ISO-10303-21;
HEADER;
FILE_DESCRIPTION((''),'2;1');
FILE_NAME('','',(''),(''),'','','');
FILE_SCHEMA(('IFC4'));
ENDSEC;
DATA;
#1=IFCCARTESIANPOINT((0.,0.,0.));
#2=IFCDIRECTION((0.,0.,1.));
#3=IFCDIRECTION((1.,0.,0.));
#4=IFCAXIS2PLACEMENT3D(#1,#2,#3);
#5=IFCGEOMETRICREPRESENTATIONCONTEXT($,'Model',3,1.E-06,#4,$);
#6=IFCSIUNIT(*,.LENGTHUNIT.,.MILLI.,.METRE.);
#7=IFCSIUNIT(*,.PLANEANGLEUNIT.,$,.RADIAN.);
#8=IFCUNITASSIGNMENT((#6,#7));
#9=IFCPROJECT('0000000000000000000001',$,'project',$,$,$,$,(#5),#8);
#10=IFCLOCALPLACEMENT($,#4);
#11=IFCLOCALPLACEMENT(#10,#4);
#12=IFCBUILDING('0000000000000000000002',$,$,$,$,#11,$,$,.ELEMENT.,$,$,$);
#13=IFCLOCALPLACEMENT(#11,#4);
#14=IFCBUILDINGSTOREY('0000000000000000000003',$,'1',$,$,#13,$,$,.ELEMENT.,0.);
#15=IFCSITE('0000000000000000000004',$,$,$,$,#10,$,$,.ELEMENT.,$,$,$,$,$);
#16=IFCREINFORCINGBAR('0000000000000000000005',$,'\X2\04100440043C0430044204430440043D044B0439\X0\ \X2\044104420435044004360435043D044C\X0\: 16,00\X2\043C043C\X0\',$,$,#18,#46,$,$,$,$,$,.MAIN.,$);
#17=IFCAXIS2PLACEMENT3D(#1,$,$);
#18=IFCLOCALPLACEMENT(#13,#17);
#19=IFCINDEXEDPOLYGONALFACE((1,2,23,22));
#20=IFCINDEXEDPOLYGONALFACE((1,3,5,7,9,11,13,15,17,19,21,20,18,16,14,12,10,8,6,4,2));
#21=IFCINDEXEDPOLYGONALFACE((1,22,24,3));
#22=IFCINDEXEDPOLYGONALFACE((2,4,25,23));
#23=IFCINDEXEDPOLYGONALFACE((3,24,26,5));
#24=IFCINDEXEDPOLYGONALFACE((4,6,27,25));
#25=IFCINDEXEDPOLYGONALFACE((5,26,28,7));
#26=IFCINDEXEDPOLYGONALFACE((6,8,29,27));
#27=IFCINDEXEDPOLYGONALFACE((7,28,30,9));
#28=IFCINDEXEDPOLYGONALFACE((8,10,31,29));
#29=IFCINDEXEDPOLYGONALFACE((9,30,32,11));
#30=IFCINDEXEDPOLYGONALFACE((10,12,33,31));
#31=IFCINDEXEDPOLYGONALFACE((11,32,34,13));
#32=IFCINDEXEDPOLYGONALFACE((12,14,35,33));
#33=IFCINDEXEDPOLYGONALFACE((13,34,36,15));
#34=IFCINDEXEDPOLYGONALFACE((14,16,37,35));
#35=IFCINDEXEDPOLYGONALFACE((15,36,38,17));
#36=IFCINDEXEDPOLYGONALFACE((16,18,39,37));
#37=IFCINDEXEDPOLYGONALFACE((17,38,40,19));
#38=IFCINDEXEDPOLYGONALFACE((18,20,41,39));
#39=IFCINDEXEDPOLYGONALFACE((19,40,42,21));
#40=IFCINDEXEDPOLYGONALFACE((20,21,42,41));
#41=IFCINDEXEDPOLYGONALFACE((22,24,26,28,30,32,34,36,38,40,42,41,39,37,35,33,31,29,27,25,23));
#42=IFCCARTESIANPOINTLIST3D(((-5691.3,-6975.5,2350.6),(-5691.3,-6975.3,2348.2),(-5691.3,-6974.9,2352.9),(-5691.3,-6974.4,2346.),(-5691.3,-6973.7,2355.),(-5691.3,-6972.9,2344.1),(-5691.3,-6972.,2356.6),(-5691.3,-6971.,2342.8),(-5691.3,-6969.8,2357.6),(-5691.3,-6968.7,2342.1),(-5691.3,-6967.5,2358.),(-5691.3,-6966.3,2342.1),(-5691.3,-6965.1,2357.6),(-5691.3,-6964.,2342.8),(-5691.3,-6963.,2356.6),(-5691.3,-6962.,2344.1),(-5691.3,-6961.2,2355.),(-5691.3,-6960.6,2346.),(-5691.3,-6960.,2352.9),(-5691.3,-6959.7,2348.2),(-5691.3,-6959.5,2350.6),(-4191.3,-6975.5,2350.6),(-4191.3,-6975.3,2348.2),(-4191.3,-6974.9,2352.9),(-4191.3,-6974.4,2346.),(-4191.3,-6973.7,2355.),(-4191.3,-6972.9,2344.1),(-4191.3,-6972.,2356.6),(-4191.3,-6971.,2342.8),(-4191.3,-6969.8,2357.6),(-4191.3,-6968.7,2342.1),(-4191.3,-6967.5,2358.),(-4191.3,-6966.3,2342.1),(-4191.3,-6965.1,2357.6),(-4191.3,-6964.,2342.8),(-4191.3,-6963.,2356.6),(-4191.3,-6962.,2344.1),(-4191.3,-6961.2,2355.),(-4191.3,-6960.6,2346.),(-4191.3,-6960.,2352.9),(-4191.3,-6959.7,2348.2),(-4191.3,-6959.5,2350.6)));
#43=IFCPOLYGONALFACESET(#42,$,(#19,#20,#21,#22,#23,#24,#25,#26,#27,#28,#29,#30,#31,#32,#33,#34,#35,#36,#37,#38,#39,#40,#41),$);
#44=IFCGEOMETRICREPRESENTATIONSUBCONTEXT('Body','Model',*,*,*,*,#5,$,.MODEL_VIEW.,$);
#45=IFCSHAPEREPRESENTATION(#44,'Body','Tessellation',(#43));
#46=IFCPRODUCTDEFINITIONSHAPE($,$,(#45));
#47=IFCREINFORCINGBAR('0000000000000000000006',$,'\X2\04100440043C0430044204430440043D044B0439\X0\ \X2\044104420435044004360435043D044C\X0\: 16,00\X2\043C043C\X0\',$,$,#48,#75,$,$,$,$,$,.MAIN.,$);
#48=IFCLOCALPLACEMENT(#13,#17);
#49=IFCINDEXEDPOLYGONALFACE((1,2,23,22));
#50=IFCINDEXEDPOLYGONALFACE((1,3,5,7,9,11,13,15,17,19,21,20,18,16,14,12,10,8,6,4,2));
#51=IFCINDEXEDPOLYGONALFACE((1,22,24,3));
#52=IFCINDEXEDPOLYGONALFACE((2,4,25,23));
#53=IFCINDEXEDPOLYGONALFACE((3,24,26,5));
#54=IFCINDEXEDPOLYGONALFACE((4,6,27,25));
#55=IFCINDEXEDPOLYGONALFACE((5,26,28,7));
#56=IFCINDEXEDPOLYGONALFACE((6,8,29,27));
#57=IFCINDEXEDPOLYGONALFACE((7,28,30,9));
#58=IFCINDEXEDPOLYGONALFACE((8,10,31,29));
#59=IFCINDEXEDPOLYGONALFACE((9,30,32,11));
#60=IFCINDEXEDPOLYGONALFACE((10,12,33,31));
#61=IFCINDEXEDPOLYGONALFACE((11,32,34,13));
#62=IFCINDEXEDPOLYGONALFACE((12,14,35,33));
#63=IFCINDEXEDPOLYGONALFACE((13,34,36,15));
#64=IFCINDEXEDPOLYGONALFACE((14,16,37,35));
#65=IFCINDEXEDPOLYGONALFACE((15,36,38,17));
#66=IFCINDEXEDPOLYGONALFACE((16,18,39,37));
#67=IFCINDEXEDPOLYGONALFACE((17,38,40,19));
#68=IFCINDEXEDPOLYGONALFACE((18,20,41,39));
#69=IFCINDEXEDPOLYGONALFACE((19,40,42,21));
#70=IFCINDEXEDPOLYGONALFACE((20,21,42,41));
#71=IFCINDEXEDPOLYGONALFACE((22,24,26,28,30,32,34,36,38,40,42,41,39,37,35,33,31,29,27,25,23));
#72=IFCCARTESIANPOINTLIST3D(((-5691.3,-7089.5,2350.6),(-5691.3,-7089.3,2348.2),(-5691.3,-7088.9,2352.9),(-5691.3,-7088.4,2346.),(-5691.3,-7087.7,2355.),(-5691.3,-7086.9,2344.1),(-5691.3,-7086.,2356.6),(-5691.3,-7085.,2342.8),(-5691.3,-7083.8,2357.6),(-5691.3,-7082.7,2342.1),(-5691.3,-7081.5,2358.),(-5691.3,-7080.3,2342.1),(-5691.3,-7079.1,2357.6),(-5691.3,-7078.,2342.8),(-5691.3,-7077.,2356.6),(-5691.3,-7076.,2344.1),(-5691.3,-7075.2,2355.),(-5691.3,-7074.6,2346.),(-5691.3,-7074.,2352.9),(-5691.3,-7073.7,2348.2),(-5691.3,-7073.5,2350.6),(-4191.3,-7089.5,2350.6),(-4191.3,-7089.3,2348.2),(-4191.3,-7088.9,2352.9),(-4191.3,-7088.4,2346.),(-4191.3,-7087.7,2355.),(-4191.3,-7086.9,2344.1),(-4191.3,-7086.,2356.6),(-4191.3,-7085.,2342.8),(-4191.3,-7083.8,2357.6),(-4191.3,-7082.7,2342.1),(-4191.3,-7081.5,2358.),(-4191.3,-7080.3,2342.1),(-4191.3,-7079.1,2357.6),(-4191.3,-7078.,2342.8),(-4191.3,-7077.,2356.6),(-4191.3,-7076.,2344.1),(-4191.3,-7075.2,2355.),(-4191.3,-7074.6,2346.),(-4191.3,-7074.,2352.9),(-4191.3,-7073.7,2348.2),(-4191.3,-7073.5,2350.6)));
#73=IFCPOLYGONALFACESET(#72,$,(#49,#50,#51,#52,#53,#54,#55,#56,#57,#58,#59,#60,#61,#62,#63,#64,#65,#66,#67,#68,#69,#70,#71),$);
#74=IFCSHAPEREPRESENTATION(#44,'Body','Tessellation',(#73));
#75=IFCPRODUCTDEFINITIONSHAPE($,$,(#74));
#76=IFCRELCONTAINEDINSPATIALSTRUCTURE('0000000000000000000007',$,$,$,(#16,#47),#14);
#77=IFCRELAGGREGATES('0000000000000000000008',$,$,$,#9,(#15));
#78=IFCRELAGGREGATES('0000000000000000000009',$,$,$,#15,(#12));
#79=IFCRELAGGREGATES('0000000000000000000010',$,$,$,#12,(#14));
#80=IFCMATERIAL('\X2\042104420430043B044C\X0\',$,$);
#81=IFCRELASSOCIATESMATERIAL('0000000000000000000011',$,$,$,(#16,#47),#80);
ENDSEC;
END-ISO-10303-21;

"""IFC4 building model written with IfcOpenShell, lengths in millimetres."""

from ifc_helpers import new_model, entity, si_unit, origin_with_axes, place, context, subcontext, project, spatial, source, transform, mapped, material, element, save


model = new_model("IFC4")

# Units and contexts
model_context = context("Model", 3, precision=1e-06, world=origin_with_axes())
body_context = subcontext(model_context, "Body", "Model", "MODEL_VIEW")
ifc_project = project(units=[si_unit("LENGTHUNIT", "METRE", prefix="MILLI"), si_unit("PLANEANGLEUNIT", "RADIAN")], contexts=[model_context])

# Site, building, storey
site_placement = place(None, origin_with_axes())
site = spatial("IfcSite", under=ifc_project, at=site_placement, CompositionType="ELEMENT")
building_placement = place(site_placement, origin_with_axes())
building = spatial("IfcBuilding", under=site, at=building_placement, CompositionType="ELEMENT")
storey_placement = place(building_placement, origin_with_axes())
storey = spatial("IfcBuildingStorey", under=building, at=storey_placement, Name="1", CompositionType="ELEMENT", Elevation=0.0)

# Reinforcing bars
ifc_material = material(Name="Сталь")
shared_shape_1 = source(origin_with_axes(), body_context, "Body", "AdvancedSweptSolid", [
    entity("IfcSweptDiskSolid", entity("IfcIndexedPolyCurve", entity("IfcCartesianPointList3D", [[0.0, 0.0, 0.0], [1500.0, 0.0, 0.0]]), [entity("IfcLineIndex", [1, 2])]), 8.0),
])
reinforcing_bar_1_placement = place(storey_placement, origin_with_axes())
element("IfcReinforcingBar", 1, at=reinforcing_bar_1_placement, inside=storey, material=ifc_material, Name="Арматурный стержень: 16,00мм", PredefinedType="MAIN", context=body_context, shape_type="MappedRepresentation", body=[
    mapped(shared_shape_1, transform((-4191.3, -6967.5, 2350.0), x_axis=(-1.0, 0.0, 0.0), y_axis=(0.0, -1.0, 0.0), z_axis=(0.0, 0.0, 1.0), scale=1.0)),
])
reinforcing_bar_2_placement = place(storey_placement, origin_with_axes())
element("IfcReinforcingBar", 2, at=reinforcing_bar_2_placement, inside=storey, material=ifc_material, Name="Арматурный стержень: 16,00мм", PredefinedType="MAIN", context=body_context, shape_type="MappedRepresentation", body=[
    mapped(shared_shape_1, transform((-4191.3, -7081.5, 2350.0), x_axis=(-1.0, 0.0, 0.0), y_axis=(0.0, -1.0, 0.0), z_axis=(0.0, 0.0, 1.0), scale=1.0)),
])

save(model, "model.ifc")
